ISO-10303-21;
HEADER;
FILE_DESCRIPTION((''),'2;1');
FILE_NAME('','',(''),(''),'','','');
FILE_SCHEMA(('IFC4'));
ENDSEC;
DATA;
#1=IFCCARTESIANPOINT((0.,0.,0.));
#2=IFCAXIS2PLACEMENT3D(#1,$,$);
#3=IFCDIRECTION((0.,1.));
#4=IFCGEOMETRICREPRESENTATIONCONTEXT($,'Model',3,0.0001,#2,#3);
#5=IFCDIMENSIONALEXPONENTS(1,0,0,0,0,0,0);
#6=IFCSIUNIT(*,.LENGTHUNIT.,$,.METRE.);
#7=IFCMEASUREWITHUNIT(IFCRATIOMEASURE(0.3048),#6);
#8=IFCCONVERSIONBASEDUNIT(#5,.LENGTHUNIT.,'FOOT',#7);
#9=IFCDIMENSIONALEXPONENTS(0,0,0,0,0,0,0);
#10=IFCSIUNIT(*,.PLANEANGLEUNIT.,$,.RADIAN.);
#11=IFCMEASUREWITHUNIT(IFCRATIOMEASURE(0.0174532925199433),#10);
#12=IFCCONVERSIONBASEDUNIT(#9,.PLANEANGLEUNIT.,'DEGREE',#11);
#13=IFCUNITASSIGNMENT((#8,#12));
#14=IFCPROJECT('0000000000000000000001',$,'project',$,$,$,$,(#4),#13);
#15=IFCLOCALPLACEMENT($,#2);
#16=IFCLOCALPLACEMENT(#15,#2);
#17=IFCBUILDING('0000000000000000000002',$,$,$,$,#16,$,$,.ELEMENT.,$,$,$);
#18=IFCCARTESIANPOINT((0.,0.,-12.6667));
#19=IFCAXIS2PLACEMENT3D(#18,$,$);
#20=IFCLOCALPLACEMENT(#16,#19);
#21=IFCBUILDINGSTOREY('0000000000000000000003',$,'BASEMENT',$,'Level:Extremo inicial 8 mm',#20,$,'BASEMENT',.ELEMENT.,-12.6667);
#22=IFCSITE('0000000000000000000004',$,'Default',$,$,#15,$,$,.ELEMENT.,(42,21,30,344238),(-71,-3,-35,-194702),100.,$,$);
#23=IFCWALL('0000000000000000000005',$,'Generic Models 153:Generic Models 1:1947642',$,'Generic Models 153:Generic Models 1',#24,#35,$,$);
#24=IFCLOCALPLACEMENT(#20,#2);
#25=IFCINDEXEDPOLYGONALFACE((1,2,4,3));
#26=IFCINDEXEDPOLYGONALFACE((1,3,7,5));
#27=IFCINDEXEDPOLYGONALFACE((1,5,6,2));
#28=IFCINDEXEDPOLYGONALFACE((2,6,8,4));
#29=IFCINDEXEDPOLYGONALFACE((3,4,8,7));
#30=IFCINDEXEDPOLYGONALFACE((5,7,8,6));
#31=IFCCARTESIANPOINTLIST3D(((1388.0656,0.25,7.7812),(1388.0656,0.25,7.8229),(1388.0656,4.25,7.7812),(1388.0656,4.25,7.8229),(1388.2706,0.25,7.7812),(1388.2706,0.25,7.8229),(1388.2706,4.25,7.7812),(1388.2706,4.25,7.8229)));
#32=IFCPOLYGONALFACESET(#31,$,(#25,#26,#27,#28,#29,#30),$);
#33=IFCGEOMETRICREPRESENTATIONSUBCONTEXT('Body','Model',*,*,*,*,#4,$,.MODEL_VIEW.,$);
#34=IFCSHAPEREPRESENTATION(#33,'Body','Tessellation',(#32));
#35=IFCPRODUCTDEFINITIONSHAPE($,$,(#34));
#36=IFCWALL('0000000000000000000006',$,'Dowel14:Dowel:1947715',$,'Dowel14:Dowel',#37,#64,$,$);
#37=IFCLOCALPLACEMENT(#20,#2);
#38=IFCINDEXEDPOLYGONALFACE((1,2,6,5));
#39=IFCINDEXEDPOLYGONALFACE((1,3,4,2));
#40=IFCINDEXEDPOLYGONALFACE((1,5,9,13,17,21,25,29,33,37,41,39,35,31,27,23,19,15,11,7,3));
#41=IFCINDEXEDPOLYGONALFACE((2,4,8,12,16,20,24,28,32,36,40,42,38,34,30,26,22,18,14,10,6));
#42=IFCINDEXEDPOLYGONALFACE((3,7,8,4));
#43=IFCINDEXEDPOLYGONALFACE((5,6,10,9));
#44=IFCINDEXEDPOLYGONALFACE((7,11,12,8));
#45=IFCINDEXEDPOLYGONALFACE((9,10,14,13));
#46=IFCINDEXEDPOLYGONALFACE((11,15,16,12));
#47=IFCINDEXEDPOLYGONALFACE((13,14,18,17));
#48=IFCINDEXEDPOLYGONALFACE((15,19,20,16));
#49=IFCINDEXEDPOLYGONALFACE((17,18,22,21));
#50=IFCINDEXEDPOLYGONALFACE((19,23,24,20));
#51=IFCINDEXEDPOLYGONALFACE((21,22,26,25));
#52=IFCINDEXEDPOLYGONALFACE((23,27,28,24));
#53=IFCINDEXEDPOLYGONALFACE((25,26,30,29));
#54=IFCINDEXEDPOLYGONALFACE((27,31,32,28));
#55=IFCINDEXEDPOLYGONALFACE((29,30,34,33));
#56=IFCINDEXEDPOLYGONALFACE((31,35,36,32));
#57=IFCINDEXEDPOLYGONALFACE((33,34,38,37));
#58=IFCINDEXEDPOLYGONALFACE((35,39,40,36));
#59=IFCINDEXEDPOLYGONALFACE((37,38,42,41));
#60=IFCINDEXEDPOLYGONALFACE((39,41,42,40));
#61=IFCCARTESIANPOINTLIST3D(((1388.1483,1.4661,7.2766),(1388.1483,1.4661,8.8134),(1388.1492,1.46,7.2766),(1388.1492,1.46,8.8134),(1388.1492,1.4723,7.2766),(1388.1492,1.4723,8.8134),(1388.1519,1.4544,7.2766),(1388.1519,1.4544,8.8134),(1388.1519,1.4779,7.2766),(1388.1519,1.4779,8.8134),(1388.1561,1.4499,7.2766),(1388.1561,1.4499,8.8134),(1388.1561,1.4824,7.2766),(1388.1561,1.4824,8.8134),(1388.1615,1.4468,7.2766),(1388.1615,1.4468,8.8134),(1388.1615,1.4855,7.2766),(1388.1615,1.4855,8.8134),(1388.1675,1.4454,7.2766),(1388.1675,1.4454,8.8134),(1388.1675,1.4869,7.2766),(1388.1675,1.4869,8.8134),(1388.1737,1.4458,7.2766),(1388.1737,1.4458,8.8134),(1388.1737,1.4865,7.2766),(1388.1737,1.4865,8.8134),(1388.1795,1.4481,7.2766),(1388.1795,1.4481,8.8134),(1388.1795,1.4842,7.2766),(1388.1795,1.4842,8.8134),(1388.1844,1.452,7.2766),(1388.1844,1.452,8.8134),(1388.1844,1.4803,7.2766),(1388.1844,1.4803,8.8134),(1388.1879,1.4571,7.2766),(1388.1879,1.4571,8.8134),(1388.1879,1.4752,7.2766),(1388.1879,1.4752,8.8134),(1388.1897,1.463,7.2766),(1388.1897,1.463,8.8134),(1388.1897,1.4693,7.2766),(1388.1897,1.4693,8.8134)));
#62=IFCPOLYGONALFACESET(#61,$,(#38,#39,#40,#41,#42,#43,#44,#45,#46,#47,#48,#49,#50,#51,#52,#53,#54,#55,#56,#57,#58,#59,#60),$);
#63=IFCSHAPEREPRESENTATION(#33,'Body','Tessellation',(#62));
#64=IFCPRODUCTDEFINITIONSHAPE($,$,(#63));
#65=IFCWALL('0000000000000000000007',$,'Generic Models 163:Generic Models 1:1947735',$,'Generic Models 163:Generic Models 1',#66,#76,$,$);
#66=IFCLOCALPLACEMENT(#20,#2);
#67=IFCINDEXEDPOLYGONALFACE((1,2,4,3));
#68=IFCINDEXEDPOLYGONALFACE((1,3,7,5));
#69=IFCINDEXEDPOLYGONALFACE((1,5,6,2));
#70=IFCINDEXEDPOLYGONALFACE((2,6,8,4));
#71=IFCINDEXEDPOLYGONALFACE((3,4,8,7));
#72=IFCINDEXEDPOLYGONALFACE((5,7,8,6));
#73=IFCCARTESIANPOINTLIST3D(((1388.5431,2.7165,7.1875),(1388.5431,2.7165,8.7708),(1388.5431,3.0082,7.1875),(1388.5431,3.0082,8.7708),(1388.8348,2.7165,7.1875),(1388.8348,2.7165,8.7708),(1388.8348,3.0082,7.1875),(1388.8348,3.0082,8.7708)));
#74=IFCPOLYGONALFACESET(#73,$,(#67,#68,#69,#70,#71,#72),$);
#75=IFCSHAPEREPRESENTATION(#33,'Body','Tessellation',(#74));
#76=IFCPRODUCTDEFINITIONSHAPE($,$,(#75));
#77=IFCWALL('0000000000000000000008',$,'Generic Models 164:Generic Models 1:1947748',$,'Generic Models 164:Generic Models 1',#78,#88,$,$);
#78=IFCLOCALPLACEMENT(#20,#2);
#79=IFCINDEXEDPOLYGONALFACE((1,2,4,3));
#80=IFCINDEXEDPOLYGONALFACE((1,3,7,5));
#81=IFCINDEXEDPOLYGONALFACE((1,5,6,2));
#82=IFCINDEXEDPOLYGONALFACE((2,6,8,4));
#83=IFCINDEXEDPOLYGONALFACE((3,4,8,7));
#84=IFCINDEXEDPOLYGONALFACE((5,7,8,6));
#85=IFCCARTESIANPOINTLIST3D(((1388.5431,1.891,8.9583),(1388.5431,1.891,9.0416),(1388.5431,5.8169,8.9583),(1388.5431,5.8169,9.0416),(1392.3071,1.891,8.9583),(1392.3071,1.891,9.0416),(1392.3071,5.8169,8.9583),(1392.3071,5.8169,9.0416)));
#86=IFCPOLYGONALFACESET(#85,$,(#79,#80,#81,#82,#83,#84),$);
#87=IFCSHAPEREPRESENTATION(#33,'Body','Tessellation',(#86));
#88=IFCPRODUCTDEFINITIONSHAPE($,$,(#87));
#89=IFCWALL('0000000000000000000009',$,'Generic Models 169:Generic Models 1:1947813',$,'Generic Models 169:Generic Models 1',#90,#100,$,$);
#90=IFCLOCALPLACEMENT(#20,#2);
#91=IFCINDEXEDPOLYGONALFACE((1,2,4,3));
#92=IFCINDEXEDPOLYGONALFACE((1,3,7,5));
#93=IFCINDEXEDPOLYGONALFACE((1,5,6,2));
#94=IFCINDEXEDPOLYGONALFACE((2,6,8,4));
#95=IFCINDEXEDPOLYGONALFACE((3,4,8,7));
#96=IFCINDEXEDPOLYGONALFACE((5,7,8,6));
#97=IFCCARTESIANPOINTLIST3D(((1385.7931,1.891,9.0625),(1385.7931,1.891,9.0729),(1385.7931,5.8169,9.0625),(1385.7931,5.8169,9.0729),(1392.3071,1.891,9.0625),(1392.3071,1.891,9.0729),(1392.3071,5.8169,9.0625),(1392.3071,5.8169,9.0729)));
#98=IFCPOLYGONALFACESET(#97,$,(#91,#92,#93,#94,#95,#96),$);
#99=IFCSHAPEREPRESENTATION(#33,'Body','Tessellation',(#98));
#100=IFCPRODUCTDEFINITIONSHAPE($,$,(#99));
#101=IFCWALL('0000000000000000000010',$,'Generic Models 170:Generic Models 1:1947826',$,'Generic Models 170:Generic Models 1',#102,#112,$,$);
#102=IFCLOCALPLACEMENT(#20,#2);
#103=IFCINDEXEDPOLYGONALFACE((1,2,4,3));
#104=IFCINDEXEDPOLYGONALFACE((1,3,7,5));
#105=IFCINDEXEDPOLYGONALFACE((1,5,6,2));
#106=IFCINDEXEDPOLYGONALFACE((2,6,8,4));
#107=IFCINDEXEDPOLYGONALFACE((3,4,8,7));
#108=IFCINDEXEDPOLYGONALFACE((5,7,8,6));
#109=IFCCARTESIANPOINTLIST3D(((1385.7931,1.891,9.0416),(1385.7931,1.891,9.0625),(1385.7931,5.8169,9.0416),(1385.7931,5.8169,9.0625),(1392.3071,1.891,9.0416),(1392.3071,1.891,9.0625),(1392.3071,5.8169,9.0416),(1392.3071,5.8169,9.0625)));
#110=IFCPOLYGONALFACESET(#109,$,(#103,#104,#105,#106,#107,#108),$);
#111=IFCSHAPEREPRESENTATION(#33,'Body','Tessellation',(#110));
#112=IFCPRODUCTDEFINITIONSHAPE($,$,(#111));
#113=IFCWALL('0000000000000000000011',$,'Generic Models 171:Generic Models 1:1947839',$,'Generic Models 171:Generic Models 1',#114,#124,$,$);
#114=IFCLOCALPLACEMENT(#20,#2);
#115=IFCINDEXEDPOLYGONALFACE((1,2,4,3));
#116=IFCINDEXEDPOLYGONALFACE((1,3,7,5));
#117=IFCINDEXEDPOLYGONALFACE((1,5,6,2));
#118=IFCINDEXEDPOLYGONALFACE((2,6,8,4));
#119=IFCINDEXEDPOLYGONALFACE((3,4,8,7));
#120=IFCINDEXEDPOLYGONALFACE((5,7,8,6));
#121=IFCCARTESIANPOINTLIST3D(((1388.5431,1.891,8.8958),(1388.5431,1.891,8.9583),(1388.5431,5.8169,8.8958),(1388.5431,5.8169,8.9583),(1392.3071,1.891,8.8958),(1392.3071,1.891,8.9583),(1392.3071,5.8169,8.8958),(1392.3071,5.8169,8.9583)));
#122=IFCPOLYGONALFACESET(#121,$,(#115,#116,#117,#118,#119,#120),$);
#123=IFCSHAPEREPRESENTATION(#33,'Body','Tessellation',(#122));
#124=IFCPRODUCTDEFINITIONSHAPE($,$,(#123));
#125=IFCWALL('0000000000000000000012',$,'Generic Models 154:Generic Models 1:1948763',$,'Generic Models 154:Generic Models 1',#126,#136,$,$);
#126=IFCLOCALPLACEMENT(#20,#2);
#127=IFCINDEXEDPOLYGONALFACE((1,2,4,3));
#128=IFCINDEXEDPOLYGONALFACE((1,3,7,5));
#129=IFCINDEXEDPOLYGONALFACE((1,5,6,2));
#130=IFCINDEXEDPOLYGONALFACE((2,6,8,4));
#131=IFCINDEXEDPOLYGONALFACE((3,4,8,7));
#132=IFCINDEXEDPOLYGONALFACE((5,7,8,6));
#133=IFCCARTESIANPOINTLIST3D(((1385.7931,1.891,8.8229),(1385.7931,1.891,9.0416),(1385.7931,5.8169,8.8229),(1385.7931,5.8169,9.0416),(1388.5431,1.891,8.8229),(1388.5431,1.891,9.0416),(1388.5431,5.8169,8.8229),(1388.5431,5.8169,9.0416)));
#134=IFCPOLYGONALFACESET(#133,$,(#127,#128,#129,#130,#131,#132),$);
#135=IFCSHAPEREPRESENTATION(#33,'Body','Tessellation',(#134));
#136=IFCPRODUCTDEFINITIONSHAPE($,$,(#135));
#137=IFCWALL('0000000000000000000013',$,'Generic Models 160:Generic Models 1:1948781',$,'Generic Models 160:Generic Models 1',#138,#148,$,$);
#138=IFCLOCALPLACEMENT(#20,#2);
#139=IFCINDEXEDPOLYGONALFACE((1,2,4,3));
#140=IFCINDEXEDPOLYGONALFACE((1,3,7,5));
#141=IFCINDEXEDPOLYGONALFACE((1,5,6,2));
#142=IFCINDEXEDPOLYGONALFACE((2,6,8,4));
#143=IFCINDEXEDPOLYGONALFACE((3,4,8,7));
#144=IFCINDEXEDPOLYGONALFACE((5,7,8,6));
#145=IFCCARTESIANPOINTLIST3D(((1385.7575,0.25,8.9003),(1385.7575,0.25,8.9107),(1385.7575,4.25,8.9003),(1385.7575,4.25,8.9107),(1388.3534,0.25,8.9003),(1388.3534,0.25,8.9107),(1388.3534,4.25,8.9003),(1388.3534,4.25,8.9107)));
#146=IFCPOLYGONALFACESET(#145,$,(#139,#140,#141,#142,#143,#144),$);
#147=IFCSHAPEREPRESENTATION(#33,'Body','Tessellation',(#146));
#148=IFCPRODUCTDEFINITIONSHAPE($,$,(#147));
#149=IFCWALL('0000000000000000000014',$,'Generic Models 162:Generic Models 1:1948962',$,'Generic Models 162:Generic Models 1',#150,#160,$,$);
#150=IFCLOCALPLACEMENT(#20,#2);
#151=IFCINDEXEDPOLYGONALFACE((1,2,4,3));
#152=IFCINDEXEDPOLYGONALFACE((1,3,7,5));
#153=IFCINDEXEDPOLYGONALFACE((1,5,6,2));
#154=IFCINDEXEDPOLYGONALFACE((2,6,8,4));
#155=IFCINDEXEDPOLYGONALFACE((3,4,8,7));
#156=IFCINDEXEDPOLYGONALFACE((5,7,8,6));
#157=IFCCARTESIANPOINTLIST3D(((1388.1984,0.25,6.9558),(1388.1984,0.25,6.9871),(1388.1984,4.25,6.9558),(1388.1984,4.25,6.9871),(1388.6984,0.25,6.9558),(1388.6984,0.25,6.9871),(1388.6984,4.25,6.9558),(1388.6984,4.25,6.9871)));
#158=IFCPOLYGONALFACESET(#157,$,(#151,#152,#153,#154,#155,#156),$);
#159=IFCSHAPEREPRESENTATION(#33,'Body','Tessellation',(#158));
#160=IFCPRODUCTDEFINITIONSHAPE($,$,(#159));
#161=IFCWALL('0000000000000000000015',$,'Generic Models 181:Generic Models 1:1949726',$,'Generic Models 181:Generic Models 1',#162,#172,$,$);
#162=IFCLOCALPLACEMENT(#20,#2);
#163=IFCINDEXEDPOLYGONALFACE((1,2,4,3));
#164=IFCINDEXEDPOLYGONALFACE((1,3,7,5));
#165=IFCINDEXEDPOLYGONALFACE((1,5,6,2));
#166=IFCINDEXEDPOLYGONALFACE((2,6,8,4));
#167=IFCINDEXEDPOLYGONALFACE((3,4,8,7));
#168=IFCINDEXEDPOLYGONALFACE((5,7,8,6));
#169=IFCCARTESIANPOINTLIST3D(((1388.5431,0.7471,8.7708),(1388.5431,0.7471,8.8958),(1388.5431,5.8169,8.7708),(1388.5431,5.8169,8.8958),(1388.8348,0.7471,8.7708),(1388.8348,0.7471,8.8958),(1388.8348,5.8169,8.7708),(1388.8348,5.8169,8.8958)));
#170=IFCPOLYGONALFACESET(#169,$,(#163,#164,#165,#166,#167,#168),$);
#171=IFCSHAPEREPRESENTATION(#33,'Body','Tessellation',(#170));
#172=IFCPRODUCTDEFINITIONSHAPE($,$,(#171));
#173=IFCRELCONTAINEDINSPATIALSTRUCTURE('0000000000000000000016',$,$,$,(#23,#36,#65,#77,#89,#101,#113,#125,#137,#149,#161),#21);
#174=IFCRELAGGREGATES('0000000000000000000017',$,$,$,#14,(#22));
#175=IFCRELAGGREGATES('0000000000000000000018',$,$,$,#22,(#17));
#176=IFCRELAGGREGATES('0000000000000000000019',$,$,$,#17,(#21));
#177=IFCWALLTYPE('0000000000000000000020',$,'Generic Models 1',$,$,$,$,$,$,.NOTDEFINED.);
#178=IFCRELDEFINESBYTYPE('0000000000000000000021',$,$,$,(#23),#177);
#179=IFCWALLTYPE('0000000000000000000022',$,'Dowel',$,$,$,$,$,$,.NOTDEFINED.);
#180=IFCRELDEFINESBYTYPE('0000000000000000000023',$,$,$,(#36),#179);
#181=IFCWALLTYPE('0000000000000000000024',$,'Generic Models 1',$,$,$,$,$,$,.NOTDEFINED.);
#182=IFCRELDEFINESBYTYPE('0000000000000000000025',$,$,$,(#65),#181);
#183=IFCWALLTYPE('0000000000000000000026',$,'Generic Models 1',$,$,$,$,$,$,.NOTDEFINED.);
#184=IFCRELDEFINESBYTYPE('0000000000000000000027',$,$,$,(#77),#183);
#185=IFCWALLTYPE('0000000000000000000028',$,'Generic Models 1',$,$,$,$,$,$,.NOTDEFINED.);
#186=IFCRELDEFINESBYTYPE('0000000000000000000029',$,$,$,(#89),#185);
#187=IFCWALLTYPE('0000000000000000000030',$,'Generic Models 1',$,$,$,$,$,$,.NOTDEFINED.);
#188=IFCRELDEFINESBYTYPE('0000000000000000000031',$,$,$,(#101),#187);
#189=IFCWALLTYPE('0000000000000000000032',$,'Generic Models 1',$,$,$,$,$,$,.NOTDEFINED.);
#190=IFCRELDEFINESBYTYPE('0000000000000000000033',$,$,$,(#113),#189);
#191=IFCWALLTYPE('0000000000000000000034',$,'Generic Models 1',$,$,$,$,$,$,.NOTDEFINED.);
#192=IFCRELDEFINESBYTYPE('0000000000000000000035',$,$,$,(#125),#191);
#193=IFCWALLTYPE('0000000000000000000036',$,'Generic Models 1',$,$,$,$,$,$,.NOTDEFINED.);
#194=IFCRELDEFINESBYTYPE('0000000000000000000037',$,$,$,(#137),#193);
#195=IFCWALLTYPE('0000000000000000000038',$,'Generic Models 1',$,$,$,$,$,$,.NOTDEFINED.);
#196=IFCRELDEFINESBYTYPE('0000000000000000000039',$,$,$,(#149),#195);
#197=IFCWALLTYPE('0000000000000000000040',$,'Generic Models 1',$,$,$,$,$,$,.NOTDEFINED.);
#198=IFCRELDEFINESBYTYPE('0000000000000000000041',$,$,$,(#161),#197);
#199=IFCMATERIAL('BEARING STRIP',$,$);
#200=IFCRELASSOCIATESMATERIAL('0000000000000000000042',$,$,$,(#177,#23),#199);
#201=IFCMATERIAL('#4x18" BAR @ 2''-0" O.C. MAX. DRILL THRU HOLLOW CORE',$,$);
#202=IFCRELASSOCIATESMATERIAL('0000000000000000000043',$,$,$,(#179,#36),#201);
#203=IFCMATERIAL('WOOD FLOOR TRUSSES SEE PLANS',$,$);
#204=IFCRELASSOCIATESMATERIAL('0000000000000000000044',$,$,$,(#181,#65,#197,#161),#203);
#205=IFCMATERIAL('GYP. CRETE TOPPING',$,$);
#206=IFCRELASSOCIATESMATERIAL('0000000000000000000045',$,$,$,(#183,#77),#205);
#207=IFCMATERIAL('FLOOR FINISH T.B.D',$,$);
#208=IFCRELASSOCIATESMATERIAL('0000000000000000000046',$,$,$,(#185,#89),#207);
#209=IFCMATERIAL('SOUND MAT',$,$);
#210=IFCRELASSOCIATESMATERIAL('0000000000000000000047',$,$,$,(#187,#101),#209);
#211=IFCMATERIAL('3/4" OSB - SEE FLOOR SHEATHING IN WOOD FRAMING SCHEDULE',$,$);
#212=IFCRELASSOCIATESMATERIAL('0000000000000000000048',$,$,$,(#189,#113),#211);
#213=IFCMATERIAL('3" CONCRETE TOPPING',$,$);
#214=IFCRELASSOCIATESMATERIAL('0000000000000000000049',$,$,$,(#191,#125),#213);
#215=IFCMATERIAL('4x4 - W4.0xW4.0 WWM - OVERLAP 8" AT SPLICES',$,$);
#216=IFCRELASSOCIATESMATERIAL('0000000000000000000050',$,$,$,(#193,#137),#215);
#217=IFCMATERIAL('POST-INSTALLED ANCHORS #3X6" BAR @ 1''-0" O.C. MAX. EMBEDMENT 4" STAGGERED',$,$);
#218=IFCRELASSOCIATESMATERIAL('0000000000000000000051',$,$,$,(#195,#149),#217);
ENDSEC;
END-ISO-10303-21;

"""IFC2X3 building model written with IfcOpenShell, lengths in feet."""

from ifc_helpers import new_model, entity, si_unit, converted_unit, direction, frame, frame_2d, origin, origin_2d_with_axis, place, context, subcontext, project, spatial, rectangle, circle, extrude, material, type_object, element, save


model = new_model("IFC2X3")

# Units and contexts
model_context = context("Model", 3, precision=0.0001, world=origin(), true_north=direction((0.0, 1.0)))
body_context = subcontext(model_context, "Body", "Model", "MODEL_VIEW")
ifc_project = project(units=[converted_unit("LENGTHUNIT", "FOOT", entity("IfcRatioMeasure", 0.3048), si_unit("LENGTHUNIT", "METRE"), dimensions=[1, 0, 0, 0, 0, 0, 0]), converted_unit("PLANEANGLEUNIT", "DEGREE", entity("IfcRatioMeasure", 0.0174532925199433), si_unit("PLANEANGLEUNIT", "RADIAN"), dimensions=[0, 0, 0, 0, 0, 0, 0])], contexts=[model_context])

# Site, building, storey
site_placement = place(None, origin())
site = spatial("IfcSite", under=ifc_project, at=site_placement, Name="Default", CompositionType="ELEMENT", RefLatitude=(42, 21, 30, 344238), RefLongitude=(-71, -3, -35, -194702), RefElevation=100.0)
building_placement = place(site_placement, origin())
building = spatial("IfcBuilding", under=site, at=building_placement, CompositionType="ELEMENT")
storey_placement = place(building_placement, frame((0.0, 0.0, -12.6667)))
storey = spatial("IfcBuildingStorey", under=building, at=storey_placement, Name="BASEMENT", ObjectType="Level:Extremo inicial 8 mm", LongName="BASEMENT", CompositionType="ELEMENT", Elevation=-12.6667)

# Walls
ifc_material_1 = material(Name="BEARING STRIP")
wall_type_1 = type_object("IfcWallType", Name="Generic Models 1", PredefinedType="NOTDEFINED", material=ifc_material_1)
wall_1_placement = place(storey_placement, frame((1388.0656, 0.25, 7.7812), z_axis=(0.0, 0.0, 1.0), x_axis=(0.0, 1.0, 0.0)))
element("IfcWall", 1, at=wall_1_placement, inside=storey, type_object=wall_type_1, material=ifc_material_1, Name="Generic Models 153:Generic Models 1:1947642", ObjectType="Generic Models 153:Generic Models 1", context=body_context, shape_type="SweptSolid", body=[
    extrude(rectangle(XDim=4.0, YDim=0.205, at=frame_2d((0.0, 0.0), x_axis=(1.0, 0.0))), frame((2.0, -0.1025, 0.0)), (0.0, 0.0, 1.0), 0.0417),
])
ifc_material_2 = material(Name="#4x18\" BAR @ 2'-0\" O.C. MAX. DRILL THRU HOLLOW CORE")
wall_type_2 = type_object("IfcWallType", Name="Dowel", PredefinedType="NOTDEFINED", material=ifc_material_2)
wall_2_placement = place(storey_placement, frame((1388.1483, 1.4453, 7.2766)))
element("IfcWall", 2, at=wall_2_placement, inside=storey, type_object=wall_type_2, material=ifc_material_2, Name="Dowel14:Dowel:1947715", ObjectType="Dowel14:Dowel", context=body_context, shape_type="SweptSolid", body=[
    extrude(circle(Radius=0.0208, at=frame_2d((0.0, 0.0), x_axis=(1.0, 0.0))), frame((0.0208, 0.0208, 0.0), z_axis=(0.0, 0.0, 1.0), x_axis=(-1.0, 0.0, 0.0)), (0.0, 0.0, 1.0), 1.5368),
])
ifc_material_3 = material(Name="WOOD FLOOR TRUSSES SEE PLANS")
wall_type_3 = type_object("IfcWallType", Name="Generic Models 1", PredefinedType="NOTDEFINED", material=ifc_material_3)
wall_3_placement = place(storey_placement, frame((1388.5431, 2.7165, 7.1875)))
element("IfcWall", 3, at=wall_3_placement, inside=storey, type_object=wall_type_3, material=ifc_material_3, Name="Generic Models 163:Generic Models 1:1947735", ObjectType="Generic Models 163:Generic Models 1", context=body_context, shape_type="SweptSolid", body=[
    extrude(rectangle(XDim=0.2917, YDim=0.2917, at=frame_2d((0.0, 0.0), x_axis=(1.0, 0.0))), frame((0.1458, 0.1458, 0.0), z_axis=(0.0, 0.0, 1.0), x_axis=(0.0, 1.0, 0.0)), (0.0, 0.0, 1.0), 1.5833),
])
ifc_material_4 = material(Name="GYP. CRETE TOPPING")
wall_type_4 = type_object("IfcWallType", Name="Generic Models 1", PredefinedType="NOTDEFINED", material=ifc_material_4)
wall_4_placement = place(storey_placement, frame((1388.5431, 1.891, 8.9583), z_axis=(0.0, 0.0, 1.0), x_axis=(0.0, 1.0, 0.0)))
element("IfcWall", 4, at=wall_4_placement, inside=storey, type_object=wall_type_4, material=ifc_material_4, Name="Generic Models 164:Generic Models 1:1947748", ObjectType="Generic Models 164:Generic Models 1", context=body_context, shape_type="SweptSolid", body=[
    extrude(rectangle(XDim=3.9258, YDim=3.7639, at=frame_2d((0.0, 0.0), x_axis=(1.0, 0.0))), frame((1.9629, -1.882, 0.0)), (0.0, 0.0, 1.0), 0.0833),
])
ifc_material_5 = material(Name="FLOOR FINISH T.B.D")
wall_type_5 = type_object("IfcWallType", Name="Generic Models 1", PredefinedType="NOTDEFINED", material=ifc_material_5)
wall_5_placement = place(storey_placement, frame((1385.7931, 1.891, 9.0625)))
element("IfcWall", 5, at=wall_5_placement, inside=storey, type_object=wall_type_5, material=ifc_material_5, Name="Generic Models 169:Generic Models 1:1947813", ObjectType="Generic Models 169:Generic Models 1", context=body_context, shape_type="SweptSolid", body=[
    extrude(rectangle(XDim=3.9258, YDim=6.5139, at=frame_2d((0.0, 0.0), x_axis=(1.0, 0.0))), frame((3.257, 1.9629, 0.0), z_axis=(0.0, 0.0, 1.0), x_axis=(0.0, 1.0, 0.0)), (0.0, 0.0, 1.0), 0.0104),
])
ifc_material_6 = material(Name="SOUND MAT")
wall_type_6 = type_object("IfcWallType", Name="Generic Models 1", PredefinedType="NOTDEFINED", material=ifc_material_6)
wall_6_placement = place(storey_placement, frame((1385.7931, 1.891, 9.0416)))
element("IfcWall", 6, at=wall_6_placement, inside=storey, type_object=wall_type_6, material=ifc_material_6, Name="Generic Models 170:Generic Models 1:1947826", ObjectType="Generic Models 170:Generic Models 1", context=body_context, shape_type="SweptSolid", body=[
    extrude(rectangle(XDim=3.9258, YDim=6.5139, at=frame_2d((0.0, 0.0), x_axis=(1.0, 0.0))), frame((3.257, 1.9629, 0.0), z_axis=(0.0, 0.0, 1.0), x_axis=(0.0, 1.0, 0.0)), (0.0, 0.0, 1.0), 0.0208),
])
ifc_material_7 = material(Name="3/4\" OSB - SEE FLOOR SHEATHING IN WOOD FRAMING SCHEDULE")
wall_type_7 = type_object("IfcWallType", Name="Generic Models 1", PredefinedType="NOTDEFINED", material=ifc_material_7)
wall_7_placement = place(storey_placement, frame((1388.5431, 1.891, 8.8958), z_axis=(0.0, 0.0, 1.0), x_axis=(0.0, 1.0, 0.0)))
element("IfcWall", 7, at=wall_7_placement, inside=storey, type_object=wall_type_7, material=ifc_material_7, Name="Generic Models 171:Generic Models 1:1947839", ObjectType="Generic Models 171:Generic Models 1", context=body_context, shape_type="SweptSolid", body=[
    extrude(rectangle(XDim=3.9258, YDim=3.7639, at=frame_2d((0.0, 0.0), x_axis=(1.0, 0.0))), frame((1.9629, -1.882, 0.0)), (0.0, 0.0, 1.0), 0.0625),
])
ifc_material_8 = material(Name="3\" CONCRETE TOPPING")
wall_type_8 = type_object("IfcWallType", Name="Generic Models 1", PredefinedType="NOTDEFINED", material=ifc_material_8)
wall_8_placement = place(storey_placement, frame((1385.7931, 1.891, 8.8229), z_axis=(0.0, 0.0, 1.0), x_axis=(0.0, 1.0, 0.0)))
element("IfcWall", 8, at=wall_8_placement, inside=storey, type_object=wall_type_8, material=ifc_material_8, Name="Generic Models 154:Generic Models 1:1948763", ObjectType="Generic Models 154:Generic Models 1", context=body_context, shape_type="SweptSolid", body=[
    extrude(rectangle(XDim=3.9258, YDim=2.75, at=frame_2d((0.0, 0.0), x_axis=(1.0, 0.0))), frame((1.9629, -1.375, 0.0)), (0.0, 0.0, 1.0), 0.2187),
])
ifc_material_9 = material(Name="4x4 - W4.0xW4.0 WWM - OVERLAP 8\" AT SPLICES")
wall_type_9 = type_object("IfcWallType", Name="Generic Models 1", PredefinedType="NOTDEFINED", material=ifc_material_9)
wall_9_placement = place(storey_placement, frame((1385.7575, 0.25, 8.9003), z_axis=(0.0, 0.0, 1.0), x_axis=(0.0, 1.0, 0.0)))
element("IfcWall", 9, at=wall_9_placement, inside=storey, type_object=wall_type_9, material=ifc_material_9, Name="Generic Models 160:Generic Models 1:1948781", ObjectType="Generic Models 160:Generic Models 1", context=body_context, shape_type="SweptSolid", body=[
    extrude(rectangle(XDim=4.0, YDim=2.5959, at=frame_2d((0.0, 0.0), x_axis=(1.0, 0.0))), frame((2.0, -1.2979, 0.0)), (0.0, 0.0, 1.0), 0.0104),
])
ifc_material_10 = material(Name="POST-INSTALLED ANCHORS #3X6\" BAR @ 1'-0\" O.C. MAX. EMBEDMENT 4\" STAGGERED")
wall_type_10 = type_object("IfcWallType", Name="Generic Models 1", PredefinedType="NOTDEFINED", material=ifc_material_10)
wall_10_placement = place(storey_placement, frame((1388.1984, 0.25, 6.9558), z_axis=(0.0, 0.0, 1.0), x_axis=(0.0, 1.0, 0.0)))
element("IfcWall", 10, at=wall_10_placement, inside=storey, type_object=wall_type_10, material=ifc_material_10, Name="Generic Models 162:Generic Models 1:1948962", ObjectType="Generic Models 162:Generic Models 1", context=body_context, shape_type="SweptSolid", body=[
    extrude(rectangle(XDim=4.0, YDim=0.5, at=origin_2d_with_axis()), frame((2.0, -0.25, 0.0)), (0.0, 0.0, 1.0), 0.0312),
])
wall_type_11 = type_object("IfcWallType", Name="Generic Models 1", PredefinedType="NOTDEFINED", material=ifc_material_3)
wall_11_placement = place(storey_placement, frame((1388.5431, 0.7471, 8.7708), z_axis=(0.0, 0.0, 1.0), x_axis=(0.0, 1.0, 0.0)))
element("IfcWall", 11, at=wall_11_placement, inside=storey, type_object=wall_type_11, material=ifc_material_3, Name="Generic Models 181:Generic Models 1:1949726", ObjectType="Generic Models 181:Generic Models 1", context=body_context, shape_type="SweptSolid", body=[
    extrude(rectangle(XDim=5.0697, YDim=0.2917, at=frame_2d((0.0, 0.0), x_axis=(1.0, 0.0))), frame((2.5349, -0.1458, 0.0)), (0.0, 0.0, 1.0), 0.125),
])

save(model, "model.ifc")
